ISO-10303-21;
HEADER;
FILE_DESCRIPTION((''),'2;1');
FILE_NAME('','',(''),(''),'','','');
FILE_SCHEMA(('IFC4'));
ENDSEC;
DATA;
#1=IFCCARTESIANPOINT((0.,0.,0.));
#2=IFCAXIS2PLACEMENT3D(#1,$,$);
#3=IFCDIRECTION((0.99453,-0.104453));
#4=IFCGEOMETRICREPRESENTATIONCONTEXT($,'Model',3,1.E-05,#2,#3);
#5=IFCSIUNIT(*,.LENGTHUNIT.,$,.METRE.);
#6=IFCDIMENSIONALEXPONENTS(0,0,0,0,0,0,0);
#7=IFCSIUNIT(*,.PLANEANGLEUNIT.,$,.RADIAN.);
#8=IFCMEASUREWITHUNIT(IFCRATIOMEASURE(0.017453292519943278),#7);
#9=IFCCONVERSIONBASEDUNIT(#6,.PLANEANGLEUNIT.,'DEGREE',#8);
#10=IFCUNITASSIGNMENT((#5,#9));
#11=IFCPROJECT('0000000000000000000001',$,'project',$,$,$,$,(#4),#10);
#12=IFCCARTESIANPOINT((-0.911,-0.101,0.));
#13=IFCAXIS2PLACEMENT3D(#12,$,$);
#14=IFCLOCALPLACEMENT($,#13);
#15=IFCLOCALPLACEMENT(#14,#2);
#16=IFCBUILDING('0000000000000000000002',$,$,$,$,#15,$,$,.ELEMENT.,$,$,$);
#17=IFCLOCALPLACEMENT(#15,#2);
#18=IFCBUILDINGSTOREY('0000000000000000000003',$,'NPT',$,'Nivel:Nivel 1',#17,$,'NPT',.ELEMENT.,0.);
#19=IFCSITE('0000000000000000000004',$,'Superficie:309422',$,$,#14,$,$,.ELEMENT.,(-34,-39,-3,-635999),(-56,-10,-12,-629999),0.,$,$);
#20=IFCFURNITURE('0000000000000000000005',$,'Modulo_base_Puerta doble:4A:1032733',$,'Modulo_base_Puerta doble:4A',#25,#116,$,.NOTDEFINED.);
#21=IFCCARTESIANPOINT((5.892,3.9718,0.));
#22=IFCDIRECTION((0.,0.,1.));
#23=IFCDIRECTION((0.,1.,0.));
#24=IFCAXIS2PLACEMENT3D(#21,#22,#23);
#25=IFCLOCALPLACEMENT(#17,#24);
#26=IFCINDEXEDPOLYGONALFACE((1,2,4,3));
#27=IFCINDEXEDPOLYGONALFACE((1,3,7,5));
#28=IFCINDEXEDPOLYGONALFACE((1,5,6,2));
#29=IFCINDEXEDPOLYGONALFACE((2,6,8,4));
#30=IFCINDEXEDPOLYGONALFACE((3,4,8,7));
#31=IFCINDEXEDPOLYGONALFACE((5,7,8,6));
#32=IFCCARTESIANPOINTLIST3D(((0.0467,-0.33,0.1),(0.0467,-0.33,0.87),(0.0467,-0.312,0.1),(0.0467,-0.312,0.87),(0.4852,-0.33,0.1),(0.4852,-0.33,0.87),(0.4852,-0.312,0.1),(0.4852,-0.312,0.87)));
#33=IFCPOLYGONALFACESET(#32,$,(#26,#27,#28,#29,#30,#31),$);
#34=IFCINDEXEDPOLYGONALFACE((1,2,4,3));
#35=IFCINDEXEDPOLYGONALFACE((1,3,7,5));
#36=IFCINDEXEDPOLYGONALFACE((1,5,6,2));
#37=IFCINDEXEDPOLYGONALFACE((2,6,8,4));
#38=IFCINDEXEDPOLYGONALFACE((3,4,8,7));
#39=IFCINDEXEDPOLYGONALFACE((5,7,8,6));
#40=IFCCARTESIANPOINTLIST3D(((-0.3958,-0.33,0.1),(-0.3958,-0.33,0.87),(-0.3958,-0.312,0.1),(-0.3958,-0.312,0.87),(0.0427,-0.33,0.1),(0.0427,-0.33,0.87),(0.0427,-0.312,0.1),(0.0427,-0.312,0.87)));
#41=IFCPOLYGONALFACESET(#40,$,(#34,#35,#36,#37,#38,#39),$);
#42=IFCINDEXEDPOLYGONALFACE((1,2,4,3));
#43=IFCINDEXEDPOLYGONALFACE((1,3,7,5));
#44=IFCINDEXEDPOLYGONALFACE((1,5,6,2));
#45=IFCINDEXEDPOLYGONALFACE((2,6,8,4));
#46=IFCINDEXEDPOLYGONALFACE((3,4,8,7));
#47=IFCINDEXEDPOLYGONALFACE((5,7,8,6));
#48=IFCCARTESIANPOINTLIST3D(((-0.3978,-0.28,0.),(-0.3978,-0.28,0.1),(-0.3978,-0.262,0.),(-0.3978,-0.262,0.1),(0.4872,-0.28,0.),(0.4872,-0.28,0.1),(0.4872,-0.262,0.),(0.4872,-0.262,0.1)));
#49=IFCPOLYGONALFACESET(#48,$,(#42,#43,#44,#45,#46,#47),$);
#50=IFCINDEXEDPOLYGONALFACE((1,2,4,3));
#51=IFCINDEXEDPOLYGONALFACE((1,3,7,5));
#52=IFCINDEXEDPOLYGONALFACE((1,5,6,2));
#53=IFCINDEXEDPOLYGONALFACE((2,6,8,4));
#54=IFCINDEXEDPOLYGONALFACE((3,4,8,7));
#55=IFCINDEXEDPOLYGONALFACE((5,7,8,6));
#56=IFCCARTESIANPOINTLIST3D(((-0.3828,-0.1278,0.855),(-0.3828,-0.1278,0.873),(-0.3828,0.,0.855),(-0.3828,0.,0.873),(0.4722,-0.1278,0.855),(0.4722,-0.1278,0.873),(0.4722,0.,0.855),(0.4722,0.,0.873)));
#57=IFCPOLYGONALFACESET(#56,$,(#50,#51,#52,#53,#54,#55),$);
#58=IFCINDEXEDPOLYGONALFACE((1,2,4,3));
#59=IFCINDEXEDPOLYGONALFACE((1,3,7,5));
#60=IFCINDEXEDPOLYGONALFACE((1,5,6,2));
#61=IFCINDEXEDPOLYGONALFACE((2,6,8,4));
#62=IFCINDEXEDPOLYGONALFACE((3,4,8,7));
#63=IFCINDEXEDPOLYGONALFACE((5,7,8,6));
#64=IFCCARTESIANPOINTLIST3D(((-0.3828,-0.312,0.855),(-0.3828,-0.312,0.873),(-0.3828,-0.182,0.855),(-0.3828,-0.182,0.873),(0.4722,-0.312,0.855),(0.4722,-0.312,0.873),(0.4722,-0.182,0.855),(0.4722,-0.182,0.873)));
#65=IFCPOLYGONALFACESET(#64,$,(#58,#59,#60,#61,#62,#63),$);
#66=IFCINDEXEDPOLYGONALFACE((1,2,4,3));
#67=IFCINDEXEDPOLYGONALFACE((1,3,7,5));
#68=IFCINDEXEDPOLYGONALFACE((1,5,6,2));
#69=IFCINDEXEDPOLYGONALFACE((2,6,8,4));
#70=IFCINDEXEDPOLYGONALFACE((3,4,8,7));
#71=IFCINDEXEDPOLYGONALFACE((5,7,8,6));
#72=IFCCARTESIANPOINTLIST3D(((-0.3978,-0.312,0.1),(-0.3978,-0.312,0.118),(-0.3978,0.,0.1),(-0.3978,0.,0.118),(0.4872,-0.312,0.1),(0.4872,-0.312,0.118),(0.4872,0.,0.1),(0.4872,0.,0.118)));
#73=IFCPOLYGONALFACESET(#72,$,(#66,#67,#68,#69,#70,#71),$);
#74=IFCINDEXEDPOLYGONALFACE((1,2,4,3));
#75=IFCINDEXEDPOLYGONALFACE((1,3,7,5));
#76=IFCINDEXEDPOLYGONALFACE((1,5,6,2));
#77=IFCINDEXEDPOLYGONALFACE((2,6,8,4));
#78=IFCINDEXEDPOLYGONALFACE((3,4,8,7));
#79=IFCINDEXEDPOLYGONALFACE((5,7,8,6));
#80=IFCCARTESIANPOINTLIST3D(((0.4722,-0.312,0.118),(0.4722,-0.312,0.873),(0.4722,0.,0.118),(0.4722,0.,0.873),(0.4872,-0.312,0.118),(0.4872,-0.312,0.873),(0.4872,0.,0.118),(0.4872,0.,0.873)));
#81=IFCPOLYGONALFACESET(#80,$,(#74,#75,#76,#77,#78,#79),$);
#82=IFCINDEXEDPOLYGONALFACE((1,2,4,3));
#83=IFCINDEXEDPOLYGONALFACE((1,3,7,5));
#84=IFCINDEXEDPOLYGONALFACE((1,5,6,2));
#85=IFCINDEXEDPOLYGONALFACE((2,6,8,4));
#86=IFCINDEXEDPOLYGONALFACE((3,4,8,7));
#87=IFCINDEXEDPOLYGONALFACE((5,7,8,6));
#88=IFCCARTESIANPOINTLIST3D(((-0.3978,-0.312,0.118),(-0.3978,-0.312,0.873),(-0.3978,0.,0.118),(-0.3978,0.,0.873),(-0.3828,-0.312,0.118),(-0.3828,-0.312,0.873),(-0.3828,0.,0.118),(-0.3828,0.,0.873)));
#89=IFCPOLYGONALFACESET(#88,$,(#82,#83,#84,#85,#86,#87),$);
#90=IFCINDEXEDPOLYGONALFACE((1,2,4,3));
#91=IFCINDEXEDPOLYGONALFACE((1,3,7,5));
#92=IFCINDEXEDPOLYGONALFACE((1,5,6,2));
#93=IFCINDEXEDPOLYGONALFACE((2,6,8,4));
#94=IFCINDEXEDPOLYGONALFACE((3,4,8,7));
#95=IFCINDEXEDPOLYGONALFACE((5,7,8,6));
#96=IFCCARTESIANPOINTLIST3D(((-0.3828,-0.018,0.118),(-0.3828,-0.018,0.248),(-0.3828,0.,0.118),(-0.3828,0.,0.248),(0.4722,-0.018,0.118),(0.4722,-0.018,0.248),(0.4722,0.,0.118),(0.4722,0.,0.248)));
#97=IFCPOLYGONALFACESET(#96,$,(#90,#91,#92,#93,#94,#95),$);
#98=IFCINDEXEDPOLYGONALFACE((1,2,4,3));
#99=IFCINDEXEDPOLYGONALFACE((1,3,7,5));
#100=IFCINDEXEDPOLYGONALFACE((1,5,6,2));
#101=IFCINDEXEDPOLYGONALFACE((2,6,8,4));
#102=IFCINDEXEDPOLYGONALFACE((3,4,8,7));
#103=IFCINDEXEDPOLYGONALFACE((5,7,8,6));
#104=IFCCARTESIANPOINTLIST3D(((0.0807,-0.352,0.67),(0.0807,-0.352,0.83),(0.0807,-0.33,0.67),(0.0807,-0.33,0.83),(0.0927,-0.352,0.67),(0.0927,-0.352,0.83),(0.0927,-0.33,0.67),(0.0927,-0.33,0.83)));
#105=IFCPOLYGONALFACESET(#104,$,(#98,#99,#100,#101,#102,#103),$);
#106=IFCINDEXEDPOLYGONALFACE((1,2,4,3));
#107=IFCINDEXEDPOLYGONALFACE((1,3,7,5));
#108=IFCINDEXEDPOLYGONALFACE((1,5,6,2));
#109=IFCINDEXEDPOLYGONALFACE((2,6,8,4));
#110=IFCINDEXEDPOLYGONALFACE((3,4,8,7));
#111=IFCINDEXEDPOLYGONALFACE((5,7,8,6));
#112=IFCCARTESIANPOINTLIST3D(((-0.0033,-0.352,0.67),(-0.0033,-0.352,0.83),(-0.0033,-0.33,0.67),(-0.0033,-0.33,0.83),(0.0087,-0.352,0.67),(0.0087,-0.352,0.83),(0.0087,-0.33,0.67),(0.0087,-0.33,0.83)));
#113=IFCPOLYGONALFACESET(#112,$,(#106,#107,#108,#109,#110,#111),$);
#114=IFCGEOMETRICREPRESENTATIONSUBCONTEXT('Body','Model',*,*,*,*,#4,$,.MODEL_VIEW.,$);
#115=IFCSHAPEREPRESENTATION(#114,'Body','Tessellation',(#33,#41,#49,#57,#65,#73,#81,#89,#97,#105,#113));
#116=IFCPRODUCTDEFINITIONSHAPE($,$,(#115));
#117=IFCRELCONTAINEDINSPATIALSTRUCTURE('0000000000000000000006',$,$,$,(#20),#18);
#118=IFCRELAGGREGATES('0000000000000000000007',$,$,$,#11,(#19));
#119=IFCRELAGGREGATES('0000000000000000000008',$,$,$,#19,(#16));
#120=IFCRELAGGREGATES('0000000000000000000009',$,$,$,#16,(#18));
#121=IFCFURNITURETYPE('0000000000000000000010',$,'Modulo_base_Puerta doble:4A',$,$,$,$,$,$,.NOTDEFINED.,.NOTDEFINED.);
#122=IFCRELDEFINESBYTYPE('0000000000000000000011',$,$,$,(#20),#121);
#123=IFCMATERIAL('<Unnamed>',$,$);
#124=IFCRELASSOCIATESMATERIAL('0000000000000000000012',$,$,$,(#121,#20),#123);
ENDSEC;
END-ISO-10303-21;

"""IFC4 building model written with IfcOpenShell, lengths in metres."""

from ifc_helpers import new_model, entity, si_unit, converted_unit, direction, frame, frame_2d, origin, origin_2d_with_axis, place, context, subcontext, project, spatial, rectangle, extrude, source, transform, mapped, material, type_object, type_shapes, element, save


model = new_model("IFC4")

# Units and contexts
model_context = context("Model", 3, precision=1e-05, world=origin(), true_north=direction((0.99453, -0.104453)))
body_context = subcontext(model_context, "Body", "Model", "MODEL_VIEW")
ifc_project = project(units=[si_unit("LENGTHUNIT", "METRE"), converted_unit("PLANEANGLEUNIT", "DEGREE", entity("IfcRatioMeasure", 0.017453292519943278), si_unit("PLANEANGLEUNIT", "RADIAN"), dimensions=[0, 0, 0, 0, 0, 0, 0])], contexts=[model_context])

# Site, building, storey
site_placement = place(None, frame((-0.911, -0.101, 0.0)))
site = spatial("IfcSite", under=ifc_project, at=site_placement, Name="Superficie:309422", CompositionType="ELEMENT", RefLatitude=(-34, -39, -3, -635999), RefLongitude=(-56, -10, -12, -629999), RefElevation=0.0)
building_placement = place(site_placement, origin())
building = spatial("IfcBuilding", under=site, at=building_placement, CompositionType="ELEMENT")
storey_placement = place(building_placement, origin())
storey = spatial("IfcBuildingStorey", under=building, at=storey_placement, Name="NPT", ObjectType="Nivel:Nivel 1", LongName="NPT", CompositionType="ELEMENT", Elevation=0.0)

# Shared definitions
ifc_material_1 = material(Name="<Unnamed>")

# Furniture
furniture_type_1 = type_object("IfcFurnitureType", Name="Modulo_base_Puerta doble:4A", AssemblyPlace="NOTDEFINED", PredefinedType="NOTDEFINED", material=ifc_material_1)
shared_shape_1 = source(origin(), body_context, "Body", "SweptSolid", [
    extrude(rectangle(XDim=0.018, YDim=0.4385, at=frame_2d((0.0, 0.0), x_axis=(1.0, 0.0))), frame((0.266, -0.321, 0.1), z_axis=(0.0, 0.0, 1.0), x_axis=(0.0, 1.0, 0.0)), (0.0, 0.0, 1.0), 0.77),
    extrude(rectangle(XDim=0.018, YDim=0.4385, at=frame_2d((0.0, 0.0), x_axis=(1.0, 0.0))), frame((-0.1765, -0.321, 0.1), z_axis=(0.0, 0.0, 1.0), x_axis=(0.0, 1.0, 0.0)), (0.0, 0.0, 1.0), 0.77),
    extrude(rectangle(XDim=0.018, YDim=0.885, at=frame_2d((0.0, 0.0), x_axis=(1.0, 0.0))), frame((0.0447, -0.271, 0.0), z_axis=(0.0, 0.0, 1.0), x_axis=(0.0, -1.0, 0.0)), (0.0, 0.0, 1.0), 0.1),
    extrude(rectangle(XDim=0.855, YDim=0.1278, at=origin_2d_with_axis()), frame((0.0447, -0.0639, 0.855), z_axis=(0.0, 0.0, 1.0), x_axis=(-1.0, 0.0, 0.0)), (0.0, 0.0, 1.0), 0.018),
    extrude(rectangle(XDim=0.855, YDim=0.13, at=frame_2d((0.0, 0.0), x_axis=(1.0, 0.0))), frame((0.0447, -0.247, 0.855), z_axis=(0.0, 0.0, 1.0), x_axis=(-1.0, 0.0, 0.0)), (0.0, 0.0, 1.0), 0.018),
    extrude(rectangle(XDim=0.885, YDim=0.312, at=frame_2d((0.0, 0.0), x_axis=(1.0, 0.0))), frame((0.0447, -0.156, 0.1), z_axis=(0.0, 0.0, 1.0), x_axis=(-1.0, 0.0, 0.0)), (0.0, 0.0, 1.0), 0.018),
    extrude(rectangle(XDim=0.015, YDim=0.312, at=frame_2d((0.0, 0.0), x_axis=(1.0, 0.0))), frame((0.4797, -0.156, 0.118)), (0.0, 0.0, 1.0), 0.755),
    extrude(rectangle(XDim=0.015, YDim=0.312, at=frame_2d((0.0, 0.0), x_axis=(1.0, 0.0))), frame((-0.3903, -0.156, 0.118), z_axis=(0.0, 0.0, 1.0), x_axis=(-1.0, 0.0, 0.0)), (0.0, 0.0, 1.0), 0.755),
    extrude(rectangle(XDim=0.855, YDim=0.018, at=frame_2d((0.0, 0.0), x_axis=(1.0, 0.0))), frame((0.0447, -0.009, 0.118), z_axis=(0.0, 0.0, 1.0), x_axis=(-1.0, 0.0, 0.0)), (0.0, 0.0, 1.0), 0.13),
    extrude(rectangle(XDim=0.022, YDim=0.012, at=frame_2d((0.0, 0.0), x_axis=(1.0, 0.0))), frame((0.0867, -0.341, 0.67), z_axis=(0.0, 0.0, 1.0), x_axis=(0.0, 1.0, 0.0)), (0.0, 0.0, 1.0), 0.16),
    extrude(rectangle(XDim=0.022, YDim=0.012, at=frame_2d((0.0, 0.0), x_axis=(1.0, 0.0))), frame((0.0027, -0.341, 0.67), z_axis=(0.0, 0.0, 1.0), x_axis=(0.0, 1.0, 0.0)), (0.0, 0.0, 1.0), 0.16),
])
type_shapes(furniture_type_1, [shared_shape_1])
furniture_1_placement = place(storey_placement, frame((5.892, 3.9718, 0.0), z_axis=(0.0, 0.0, 1.0), x_axis=(0.0, 1.0, 0.0)))
element("IfcFurniture", 1, at=furniture_1_placement, inside=storey, type_object=furniture_type_1, material=ifc_material_1, Name="Modulo_base_Puerta doble:4A:1032733", ObjectType="Modulo_base_Puerta doble:4A", PredefinedType="NOTDEFINED", context=body_context, shape_type="MappedRepresentation", body=[
    mapped(shared_shape_1, transform((0.0, 0.0, 0.0), scale=1.0)),
])

save(model, "model.ifc")
